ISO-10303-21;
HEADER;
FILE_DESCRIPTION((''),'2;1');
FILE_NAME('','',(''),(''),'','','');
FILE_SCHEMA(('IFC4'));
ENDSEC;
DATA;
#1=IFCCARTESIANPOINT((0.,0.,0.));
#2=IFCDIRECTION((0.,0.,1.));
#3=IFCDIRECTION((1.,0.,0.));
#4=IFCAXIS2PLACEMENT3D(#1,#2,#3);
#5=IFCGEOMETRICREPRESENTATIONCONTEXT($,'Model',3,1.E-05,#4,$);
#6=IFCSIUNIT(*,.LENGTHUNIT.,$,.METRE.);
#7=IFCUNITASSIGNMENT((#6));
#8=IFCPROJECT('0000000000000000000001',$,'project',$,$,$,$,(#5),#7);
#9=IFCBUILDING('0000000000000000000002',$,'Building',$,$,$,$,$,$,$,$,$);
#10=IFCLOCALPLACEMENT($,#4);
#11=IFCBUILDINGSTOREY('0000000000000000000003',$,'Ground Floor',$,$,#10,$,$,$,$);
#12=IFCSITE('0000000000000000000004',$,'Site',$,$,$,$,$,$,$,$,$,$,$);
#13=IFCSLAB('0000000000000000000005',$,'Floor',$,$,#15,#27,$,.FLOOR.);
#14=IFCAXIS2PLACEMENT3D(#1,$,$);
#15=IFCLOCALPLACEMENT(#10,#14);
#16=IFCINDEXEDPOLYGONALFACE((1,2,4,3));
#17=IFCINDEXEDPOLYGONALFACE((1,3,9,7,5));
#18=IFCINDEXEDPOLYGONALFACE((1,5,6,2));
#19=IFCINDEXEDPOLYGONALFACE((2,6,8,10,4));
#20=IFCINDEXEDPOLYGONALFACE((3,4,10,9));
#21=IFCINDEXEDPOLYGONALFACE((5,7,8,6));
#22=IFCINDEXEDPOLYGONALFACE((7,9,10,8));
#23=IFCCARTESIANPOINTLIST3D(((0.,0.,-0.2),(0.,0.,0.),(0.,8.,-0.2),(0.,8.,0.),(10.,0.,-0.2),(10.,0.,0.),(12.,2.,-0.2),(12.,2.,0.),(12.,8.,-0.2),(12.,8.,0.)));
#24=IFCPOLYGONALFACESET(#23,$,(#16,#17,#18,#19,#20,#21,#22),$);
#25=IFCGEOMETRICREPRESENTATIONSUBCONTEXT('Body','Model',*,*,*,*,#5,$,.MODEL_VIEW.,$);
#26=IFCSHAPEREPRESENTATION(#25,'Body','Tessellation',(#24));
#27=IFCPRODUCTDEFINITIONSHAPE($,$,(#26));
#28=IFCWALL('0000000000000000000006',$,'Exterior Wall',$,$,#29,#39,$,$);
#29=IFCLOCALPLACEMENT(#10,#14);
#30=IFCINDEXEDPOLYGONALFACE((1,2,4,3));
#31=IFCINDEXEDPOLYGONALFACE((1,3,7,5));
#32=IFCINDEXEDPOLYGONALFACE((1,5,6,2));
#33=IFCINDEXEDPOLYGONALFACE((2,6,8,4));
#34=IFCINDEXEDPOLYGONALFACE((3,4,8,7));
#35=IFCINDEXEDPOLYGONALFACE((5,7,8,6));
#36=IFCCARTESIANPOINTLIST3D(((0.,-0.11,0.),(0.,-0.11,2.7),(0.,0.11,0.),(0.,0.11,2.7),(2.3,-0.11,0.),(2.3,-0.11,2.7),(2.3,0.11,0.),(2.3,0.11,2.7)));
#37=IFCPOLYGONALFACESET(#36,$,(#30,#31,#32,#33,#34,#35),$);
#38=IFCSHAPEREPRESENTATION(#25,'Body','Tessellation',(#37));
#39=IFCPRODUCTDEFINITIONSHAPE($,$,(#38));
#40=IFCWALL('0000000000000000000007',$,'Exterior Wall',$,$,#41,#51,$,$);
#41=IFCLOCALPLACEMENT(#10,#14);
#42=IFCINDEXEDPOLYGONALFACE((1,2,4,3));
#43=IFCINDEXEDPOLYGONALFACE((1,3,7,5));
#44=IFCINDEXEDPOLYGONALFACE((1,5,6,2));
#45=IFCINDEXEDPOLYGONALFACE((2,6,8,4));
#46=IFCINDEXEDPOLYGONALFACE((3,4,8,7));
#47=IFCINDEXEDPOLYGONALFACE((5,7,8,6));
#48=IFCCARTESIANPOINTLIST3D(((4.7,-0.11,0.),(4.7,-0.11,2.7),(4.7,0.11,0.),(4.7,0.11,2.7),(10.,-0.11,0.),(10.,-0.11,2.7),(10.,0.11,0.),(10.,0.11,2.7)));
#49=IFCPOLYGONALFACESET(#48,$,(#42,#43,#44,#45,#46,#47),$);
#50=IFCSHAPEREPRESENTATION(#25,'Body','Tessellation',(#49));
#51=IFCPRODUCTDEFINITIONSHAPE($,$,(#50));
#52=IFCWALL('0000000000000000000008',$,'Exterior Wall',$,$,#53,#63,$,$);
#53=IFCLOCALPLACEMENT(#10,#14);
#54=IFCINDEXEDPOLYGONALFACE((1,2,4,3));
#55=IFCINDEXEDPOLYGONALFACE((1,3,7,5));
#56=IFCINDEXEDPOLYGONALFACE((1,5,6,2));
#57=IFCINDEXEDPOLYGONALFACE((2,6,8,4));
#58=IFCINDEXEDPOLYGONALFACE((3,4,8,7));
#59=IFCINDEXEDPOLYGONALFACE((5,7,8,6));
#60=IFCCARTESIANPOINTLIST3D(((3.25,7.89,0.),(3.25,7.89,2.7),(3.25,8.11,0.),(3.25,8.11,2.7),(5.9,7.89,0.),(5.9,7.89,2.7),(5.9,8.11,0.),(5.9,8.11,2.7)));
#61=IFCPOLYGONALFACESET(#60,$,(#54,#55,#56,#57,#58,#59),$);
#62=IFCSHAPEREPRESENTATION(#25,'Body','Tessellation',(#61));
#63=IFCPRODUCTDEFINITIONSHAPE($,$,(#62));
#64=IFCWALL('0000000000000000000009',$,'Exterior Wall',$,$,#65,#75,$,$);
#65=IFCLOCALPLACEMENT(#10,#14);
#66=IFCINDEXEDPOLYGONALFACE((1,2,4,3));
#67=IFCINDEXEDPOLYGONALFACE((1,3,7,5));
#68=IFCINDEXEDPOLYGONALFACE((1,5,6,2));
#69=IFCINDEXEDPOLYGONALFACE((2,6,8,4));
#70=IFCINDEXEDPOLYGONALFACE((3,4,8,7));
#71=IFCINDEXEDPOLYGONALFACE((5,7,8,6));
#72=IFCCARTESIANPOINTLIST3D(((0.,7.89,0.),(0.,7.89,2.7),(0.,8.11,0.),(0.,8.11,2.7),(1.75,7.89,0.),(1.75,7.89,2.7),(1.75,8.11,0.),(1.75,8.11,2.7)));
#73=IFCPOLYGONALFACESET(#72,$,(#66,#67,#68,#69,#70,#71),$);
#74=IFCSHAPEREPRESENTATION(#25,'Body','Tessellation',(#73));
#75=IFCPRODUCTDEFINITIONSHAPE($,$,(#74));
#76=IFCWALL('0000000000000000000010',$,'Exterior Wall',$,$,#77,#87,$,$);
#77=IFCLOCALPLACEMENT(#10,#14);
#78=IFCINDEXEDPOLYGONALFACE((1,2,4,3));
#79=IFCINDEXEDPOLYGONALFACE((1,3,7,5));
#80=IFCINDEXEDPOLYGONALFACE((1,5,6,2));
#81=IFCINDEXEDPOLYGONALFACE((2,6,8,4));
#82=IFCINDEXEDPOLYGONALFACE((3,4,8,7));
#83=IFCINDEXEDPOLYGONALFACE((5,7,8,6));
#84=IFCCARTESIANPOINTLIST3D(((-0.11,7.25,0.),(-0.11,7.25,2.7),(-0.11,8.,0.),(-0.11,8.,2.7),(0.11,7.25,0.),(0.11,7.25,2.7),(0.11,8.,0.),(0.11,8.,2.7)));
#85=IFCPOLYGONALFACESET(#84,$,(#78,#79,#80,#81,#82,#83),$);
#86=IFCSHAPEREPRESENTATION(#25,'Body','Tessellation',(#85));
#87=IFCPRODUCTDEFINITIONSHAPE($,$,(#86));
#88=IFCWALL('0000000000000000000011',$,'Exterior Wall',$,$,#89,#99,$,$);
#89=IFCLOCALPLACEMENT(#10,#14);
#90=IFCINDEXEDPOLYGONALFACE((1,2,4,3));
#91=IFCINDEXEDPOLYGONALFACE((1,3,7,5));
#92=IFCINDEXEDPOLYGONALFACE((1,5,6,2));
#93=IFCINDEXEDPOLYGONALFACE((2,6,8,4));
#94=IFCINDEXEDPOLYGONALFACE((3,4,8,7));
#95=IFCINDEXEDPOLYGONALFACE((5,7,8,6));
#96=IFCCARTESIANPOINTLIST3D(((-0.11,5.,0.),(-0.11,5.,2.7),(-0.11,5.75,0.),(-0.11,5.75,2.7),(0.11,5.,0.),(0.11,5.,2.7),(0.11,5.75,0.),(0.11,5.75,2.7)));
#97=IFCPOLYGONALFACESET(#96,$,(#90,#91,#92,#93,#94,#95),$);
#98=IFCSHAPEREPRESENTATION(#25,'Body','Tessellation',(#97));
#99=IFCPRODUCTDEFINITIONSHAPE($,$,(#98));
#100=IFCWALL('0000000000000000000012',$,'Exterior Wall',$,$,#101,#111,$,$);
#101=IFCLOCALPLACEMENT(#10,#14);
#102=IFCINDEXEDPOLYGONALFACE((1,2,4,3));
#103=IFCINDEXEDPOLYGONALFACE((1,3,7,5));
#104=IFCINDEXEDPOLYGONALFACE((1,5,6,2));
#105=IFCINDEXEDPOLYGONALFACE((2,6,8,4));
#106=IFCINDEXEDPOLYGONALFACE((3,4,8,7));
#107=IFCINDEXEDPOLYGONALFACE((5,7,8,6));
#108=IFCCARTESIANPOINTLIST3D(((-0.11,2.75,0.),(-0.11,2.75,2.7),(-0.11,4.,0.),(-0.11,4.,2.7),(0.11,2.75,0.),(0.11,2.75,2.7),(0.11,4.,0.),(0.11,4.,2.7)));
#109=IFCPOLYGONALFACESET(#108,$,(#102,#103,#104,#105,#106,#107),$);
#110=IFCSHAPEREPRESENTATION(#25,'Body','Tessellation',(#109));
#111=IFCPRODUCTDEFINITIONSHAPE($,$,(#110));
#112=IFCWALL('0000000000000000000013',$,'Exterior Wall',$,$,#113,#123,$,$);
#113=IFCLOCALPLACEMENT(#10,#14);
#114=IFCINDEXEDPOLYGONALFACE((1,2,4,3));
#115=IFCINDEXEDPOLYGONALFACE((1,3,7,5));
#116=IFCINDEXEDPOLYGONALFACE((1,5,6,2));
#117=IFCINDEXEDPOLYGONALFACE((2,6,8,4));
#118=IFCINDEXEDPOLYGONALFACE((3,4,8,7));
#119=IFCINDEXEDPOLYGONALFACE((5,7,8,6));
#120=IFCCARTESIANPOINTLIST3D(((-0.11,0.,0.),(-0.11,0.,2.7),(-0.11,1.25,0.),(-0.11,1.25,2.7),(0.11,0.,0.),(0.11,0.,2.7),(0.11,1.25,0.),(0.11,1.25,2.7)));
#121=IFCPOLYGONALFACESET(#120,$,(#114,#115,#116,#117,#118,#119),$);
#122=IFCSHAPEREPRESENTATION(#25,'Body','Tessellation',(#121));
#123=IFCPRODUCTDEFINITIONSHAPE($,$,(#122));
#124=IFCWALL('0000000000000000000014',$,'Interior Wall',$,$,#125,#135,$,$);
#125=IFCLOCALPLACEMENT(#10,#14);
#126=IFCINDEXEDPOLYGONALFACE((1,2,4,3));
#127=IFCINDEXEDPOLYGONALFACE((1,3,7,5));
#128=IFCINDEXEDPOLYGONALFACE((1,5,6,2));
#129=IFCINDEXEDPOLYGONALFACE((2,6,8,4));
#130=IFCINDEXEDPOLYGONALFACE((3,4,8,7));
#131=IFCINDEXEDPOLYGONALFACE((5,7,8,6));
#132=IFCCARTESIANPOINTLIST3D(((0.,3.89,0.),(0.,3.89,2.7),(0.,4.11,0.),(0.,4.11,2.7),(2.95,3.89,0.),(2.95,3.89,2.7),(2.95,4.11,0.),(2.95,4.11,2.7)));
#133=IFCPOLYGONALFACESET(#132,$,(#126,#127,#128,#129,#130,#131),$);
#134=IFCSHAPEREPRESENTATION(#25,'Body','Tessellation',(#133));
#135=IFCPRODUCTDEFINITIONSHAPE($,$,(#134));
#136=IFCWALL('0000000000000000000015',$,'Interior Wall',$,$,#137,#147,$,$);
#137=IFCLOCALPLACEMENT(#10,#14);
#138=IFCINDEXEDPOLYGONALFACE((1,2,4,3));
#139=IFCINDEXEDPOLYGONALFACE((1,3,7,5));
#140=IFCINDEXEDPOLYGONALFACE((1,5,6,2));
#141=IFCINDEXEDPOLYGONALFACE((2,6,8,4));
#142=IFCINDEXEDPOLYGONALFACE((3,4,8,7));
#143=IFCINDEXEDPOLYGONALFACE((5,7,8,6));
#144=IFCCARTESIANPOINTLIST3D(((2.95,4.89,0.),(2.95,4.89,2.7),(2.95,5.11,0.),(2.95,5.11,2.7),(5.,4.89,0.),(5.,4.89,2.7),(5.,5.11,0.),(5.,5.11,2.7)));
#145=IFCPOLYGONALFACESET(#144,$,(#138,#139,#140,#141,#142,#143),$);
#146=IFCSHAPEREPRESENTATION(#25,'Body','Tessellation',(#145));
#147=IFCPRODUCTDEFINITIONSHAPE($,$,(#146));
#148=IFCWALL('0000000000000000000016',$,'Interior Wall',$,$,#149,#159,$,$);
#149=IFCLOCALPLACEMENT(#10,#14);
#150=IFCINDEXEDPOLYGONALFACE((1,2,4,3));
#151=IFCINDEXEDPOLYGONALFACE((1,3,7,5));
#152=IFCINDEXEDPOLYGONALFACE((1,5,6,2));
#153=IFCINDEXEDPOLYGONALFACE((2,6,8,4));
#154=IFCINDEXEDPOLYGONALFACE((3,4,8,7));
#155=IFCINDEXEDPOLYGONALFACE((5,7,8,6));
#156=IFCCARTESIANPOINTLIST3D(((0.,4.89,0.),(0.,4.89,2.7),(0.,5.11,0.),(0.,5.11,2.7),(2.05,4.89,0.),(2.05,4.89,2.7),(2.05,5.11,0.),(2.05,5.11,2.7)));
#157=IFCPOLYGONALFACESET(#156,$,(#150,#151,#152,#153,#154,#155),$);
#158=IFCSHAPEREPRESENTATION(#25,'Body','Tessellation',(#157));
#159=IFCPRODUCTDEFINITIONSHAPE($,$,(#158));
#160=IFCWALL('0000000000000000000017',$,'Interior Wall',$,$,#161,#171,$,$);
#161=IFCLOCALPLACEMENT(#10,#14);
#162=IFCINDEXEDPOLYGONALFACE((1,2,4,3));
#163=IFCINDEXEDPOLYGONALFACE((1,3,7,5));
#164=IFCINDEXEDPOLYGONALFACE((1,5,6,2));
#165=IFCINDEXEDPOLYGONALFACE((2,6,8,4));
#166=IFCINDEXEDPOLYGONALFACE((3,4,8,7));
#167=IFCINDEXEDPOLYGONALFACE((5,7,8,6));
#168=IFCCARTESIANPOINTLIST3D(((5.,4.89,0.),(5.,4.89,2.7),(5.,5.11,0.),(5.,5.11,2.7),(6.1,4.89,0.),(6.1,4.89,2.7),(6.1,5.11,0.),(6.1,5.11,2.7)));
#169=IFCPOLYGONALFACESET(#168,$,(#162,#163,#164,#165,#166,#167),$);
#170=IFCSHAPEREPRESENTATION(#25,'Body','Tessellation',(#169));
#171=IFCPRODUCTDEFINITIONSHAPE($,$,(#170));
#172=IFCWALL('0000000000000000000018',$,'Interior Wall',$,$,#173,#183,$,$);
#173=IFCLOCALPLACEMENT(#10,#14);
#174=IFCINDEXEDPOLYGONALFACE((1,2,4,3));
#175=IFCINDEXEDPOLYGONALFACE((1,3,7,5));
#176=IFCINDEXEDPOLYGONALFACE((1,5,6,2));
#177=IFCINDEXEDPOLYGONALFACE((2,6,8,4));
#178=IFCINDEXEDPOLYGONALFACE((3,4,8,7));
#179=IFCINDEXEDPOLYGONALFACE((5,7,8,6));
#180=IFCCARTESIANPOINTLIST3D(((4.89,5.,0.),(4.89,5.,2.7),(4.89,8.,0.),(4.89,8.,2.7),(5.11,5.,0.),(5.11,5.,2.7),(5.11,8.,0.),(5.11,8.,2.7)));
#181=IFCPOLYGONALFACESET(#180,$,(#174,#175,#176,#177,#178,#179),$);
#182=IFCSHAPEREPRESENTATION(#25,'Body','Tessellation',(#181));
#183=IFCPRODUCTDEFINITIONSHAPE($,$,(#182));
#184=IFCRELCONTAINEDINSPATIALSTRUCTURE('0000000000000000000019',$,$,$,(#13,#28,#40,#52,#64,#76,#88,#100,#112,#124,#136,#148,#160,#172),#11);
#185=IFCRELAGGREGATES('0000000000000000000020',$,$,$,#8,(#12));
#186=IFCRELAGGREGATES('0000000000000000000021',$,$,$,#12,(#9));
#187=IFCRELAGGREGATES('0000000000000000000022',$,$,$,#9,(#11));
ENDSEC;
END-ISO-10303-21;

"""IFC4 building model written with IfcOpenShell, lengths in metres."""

from ifc_helpers import new_model, si_unit, frame, origin_with_axes, place, context, subcontext, project, spatial, indexed_curve, outline, extrude, element, save


model = new_model("IFC4")

# Units and contexts
model_context = context("Model", 3, precision=1e-05, world=origin_with_axes())
body_context = subcontext(model_context, "Body", "Model", "MODEL_VIEW")
ifc_project = project(units=[si_unit("LENGTHUNIT", "METRE")], contexts=[model_context])

# Site, building, storey
site = spatial("IfcSite", under=ifc_project, Name="Site")
building = spatial("IfcBuilding", under=site, Name="Building")
storey_placement = place(None, origin_with_axes())
storey = spatial("IfcBuildingStorey", under=building, at=storey_placement, Name="Ground Floor")

# Slab
slab_placement = place(storey_placement, frame((0.0, 0.0, -0.2), z_axis=(0.0, 0.0, 1.0), x_axis=(1.0, 0.0, 0.0)))
element("IfcSlab", 1, at=slab_placement, inside=storey, Name="Floor", PredefinedType="FLOOR", context=body_context, shape_type="SweptSolid", body=[
    extrude(outline(indexed_curve([(0.0, 0.0), (10.0, 0.0), (12.0, 2.0), (12.0, 8.0), (0.0, 8.0)])), None, (0.0, 0.0, 1.0), 0.2),
])

# Walls
wall_1_placement = place(storey_placement, origin_with_axes())
element("IfcWall", 2, at=wall_1_placement, inside=storey, Name="Exterior Wall", context=body_context, shape_type="SweptSolid", body=[
    extrude(outline(indexed_curve([(0.0, 0.0), (0.0, 0.22), (2.3, 0.22), (2.3, 0.0), (0.0, 0.0)], self_intersect=False)), frame((0.0, -0.11, 0.0), z_axis=(0.0, 0.0, 1.0), x_axis=(1.0, 0.0, 0.0)), (0.0, 0.0, 1.0), 2.7),
])
wall_2_placement = place(storey_placement, frame((4.7, 0.0, 0.0), z_axis=(0.0, 0.0, 1.0), x_axis=(1.0, 0.0, 0.0)))
element("IfcWall", 3, at=wall_2_placement, inside=storey, Name="Exterior Wall", context=body_context, shape_type="SweptSolid", body=[
    extrude(outline(indexed_curve([(0.0, 0.0), (0.0, 0.22), (5.3, 0.22), (5.3, 0.0), (0.0, 0.0)], self_intersect=False)), frame((0.0, -0.11, 0.0), z_axis=(0.0, 0.0, 1.0), x_axis=(1.0, 0.0, 0.0)), (0.0, 0.0, 1.0), 2.7),
])
wall_3_placement = place(storey_placement, frame((5.9, 8.0, 0.0), z_axis=(0.0, 0.0, 1.0), x_axis=(-1.0, 0.0, 0.0)))
element("IfcWall", 4, at=wall_3_placement, inside=storey, Name="Exterior Wall", context=body_context, shape_type="SweptSolid", body=[
    extrude(outline(indexed_curve([(0.0, 0.0), (0.0, 0.22), (2.65, 0.22), (2.65, 0.0), (0.0, 0.0)], self_intersect=False)), frame((0.0, -0.11, 0.0), z_axis=(0.0, 0.0, 1.0), x_axis=(1.0, 0.0, 0.0)), (0.0, 0.0, 1.0), 2.7),
])
wall_4_placement = place(storey_placement, frame((1.75, 8.0, 0.0), z_axis=(0.0, 0.0, 1.0), x_axis=(-1.0, 0.0, 0.0)))
element("IfcWall", 5, at=wall_4_placement, inside=storey, Name="Exterior Wall", context=body_context, shape_type="SweptSolid", body=[
    extrude(outline(indexed_curve([(0.0, 0.0), (0.0, 0.22), (1.75, 0.22), (1.75, 0.0), (0.0, 0.0)], self_intersect=False)), frame((0.0, -0.11, 0.0), z_axis=(0.0, 0.0, 1.0), x_axis=(1.0, 0.0, 0.0)), (0.0, 0.0, 1.0), 2.7),
])
for number, where, z_axis, x_axis, name in (
    (6, (0.0, 8.0, 0.0), (0.0, 0.0, 1.0), (0.0, -1.0, 0.0), "Exterior Wall"),
    (7, (0.0, 5.75, 0.0), (0.0, 0.0, 1.0), (0.0, -1.0, 0.0), "Exterior Wall"),
):
    element("IfcWall", number, at=place(storey_placement, frame(where, z_axis=z_axis, x_axis=x_axis)), inside=storey, Name=name, context=body_context, shape_type="SweptSolid", body=[
        extrude(outline(indexed_curve([(0.0, 0.0), (0.0, 0.22), (0.75, 0.22), (0.75, 0.0), (0.0, 0.0)], self_intersect=False)), frame((0.0, -0.11, 0.0), z_axis=(0.0, 0.0, 1.0), x_axis=(1.0, 0.0, 0.0)), (0.0, 0.0, 1.0), 2.7),
    ])
for number, where, z_axis, x_axis, name in (
    (8, (0.0, 4.0, 0.0), (0.0, 0.0, 1.0), (0.0, -1.0, 0.0), "Exterior Wall"),
    (9, (0.0, 1.25, 0.0), (0.0, 0.0, 1.0), (0.0, -1.0, 0.0), "Exterior Wall"),
):
    element("IfcWall", number, at=place(storey_placement, frame(where, z_axis=z_axis, x_axis=x_axis)), inside=storey, Name=name, context=body_context, shape_type="SweptSolid", body=[
        extrude(outline(indexed_curve([(0.0, 0.0), (0.0, 0.22), (1.25, 0.22), (1.25, 0.0), (0.0, 0.0)], self_intersect=False)), frame((0.0, -0.11, 0.0), z_axis=(0.0, 0.0, 1.0), x_axis=(1.0, 0.0, 0.0)), (0.0, 0.0, 1.0), 2.7),
    ])
wall_5_placement = place(storey_placement, frame((2.95, 4.0, 0.0), z_axis=(0.0, 0.0, 1.0), x_axis=(-1.0, 0.0, 0.0)))
element("IfcWall", 10, at=wall_5_placement, inside=storey, Name="Interior Wall", context=body_context, shape_type="SweptSolid", body=[
    extrude(outline(indexed_curve([(0.0, 0.0), (0.0, 0.22), (2.95, 0.22), (2.95, 0.0), (0.0, 0.0)], self_intersect=False)), frame((0.0, -0.11, 0.0), z_axis=(0.0, 0.0, 1.0), x_axis=(1.0, 0.0, 0.0)), (0.0, 0.0, 1.0), 2.7),
])
for number, where, z_axis, x_axis, name in (
    (11, (5.0, 5.0, 0.0), (0.0, 0.0, 1.0), (-1.0, 0.0, 0.0), "Interior Wall"),
    (12, (2.05, 5.0, 0.0), (0.0, 0.0, 1.0), (-1.0, 0.0, 0.0), "Interior Wall"),
):
    element("IfcWall", number, at=place(storey_placement, frame(where, z_axis=z_axis, x_axis=x_axis)), inside=storey, Name=name, context=body_context, shape_type="SweptSolid", body=[
        extrude(outline(indexed_curve([(0.0, 0.0), (0.0, 0.22), (2.05, 0.22), (2.05, 0.0), (0.0, 0.0)], self_intersect=False)), frame((0.0, -0.11, 0.0), z_axis=(0.0, 0.0, 1.0), x_axis=(1.0, 0.0, 0.0)), (0.0, 0.0, 1.0), 2.7),
    ])
wall_6_placement = place(storey_placement, frame((6.1, 5.0, 0.0), z_axis=(0.0, 0.0, 1.0), x_axis=(-1.0, 0.0, 0.0)))
element("IfcWall", 13, at=wall_6_placement, inside=storey, Name="Interior Wall", context=body_context, shape_type="SweptSolid", body=[
    extrude(outline(indexed_curve([(0.0, 0.0), (0.0, 0.22), (1.1, 0.22), (1.1, 0.0), (0.0, 0.0)], self_intersect=False)), frame((0.0, -0.11, 0.0), z_axis=(0.0, 0.0, 1.0), x_axis=(1.0, 0.0, 0.0)), (0.0, 0.0, 1.0), 2.7),
])
wall_7_placement = place(storey_placement, frame((5.0, 5.0, 0.0), z_axis=(0.0, 0.0, 1.0), x_axis=(0.0, 1.0, 0.0)))
element("IfcWall", 14, at=wall_7_placement, inside=storey, Name="Interior Wall", context=body_context, shape_type="SweptSolid", body=[
    extrude(outline(indexed_curve([(0.0, 0.0), (0.0, 0.22), (3.0, 0.22), (3.0, 0.0), (0.0, 0.0)], self_intersect=False)), frame((0.0, -0.11, 0.0), z_axis=(0.0, 0.0, 1.0), x_axis=(1.0, 0.0, 0.0)), (0.0, 0.0, 1.0), 2.7),
])

save(model, "model.ifc")
